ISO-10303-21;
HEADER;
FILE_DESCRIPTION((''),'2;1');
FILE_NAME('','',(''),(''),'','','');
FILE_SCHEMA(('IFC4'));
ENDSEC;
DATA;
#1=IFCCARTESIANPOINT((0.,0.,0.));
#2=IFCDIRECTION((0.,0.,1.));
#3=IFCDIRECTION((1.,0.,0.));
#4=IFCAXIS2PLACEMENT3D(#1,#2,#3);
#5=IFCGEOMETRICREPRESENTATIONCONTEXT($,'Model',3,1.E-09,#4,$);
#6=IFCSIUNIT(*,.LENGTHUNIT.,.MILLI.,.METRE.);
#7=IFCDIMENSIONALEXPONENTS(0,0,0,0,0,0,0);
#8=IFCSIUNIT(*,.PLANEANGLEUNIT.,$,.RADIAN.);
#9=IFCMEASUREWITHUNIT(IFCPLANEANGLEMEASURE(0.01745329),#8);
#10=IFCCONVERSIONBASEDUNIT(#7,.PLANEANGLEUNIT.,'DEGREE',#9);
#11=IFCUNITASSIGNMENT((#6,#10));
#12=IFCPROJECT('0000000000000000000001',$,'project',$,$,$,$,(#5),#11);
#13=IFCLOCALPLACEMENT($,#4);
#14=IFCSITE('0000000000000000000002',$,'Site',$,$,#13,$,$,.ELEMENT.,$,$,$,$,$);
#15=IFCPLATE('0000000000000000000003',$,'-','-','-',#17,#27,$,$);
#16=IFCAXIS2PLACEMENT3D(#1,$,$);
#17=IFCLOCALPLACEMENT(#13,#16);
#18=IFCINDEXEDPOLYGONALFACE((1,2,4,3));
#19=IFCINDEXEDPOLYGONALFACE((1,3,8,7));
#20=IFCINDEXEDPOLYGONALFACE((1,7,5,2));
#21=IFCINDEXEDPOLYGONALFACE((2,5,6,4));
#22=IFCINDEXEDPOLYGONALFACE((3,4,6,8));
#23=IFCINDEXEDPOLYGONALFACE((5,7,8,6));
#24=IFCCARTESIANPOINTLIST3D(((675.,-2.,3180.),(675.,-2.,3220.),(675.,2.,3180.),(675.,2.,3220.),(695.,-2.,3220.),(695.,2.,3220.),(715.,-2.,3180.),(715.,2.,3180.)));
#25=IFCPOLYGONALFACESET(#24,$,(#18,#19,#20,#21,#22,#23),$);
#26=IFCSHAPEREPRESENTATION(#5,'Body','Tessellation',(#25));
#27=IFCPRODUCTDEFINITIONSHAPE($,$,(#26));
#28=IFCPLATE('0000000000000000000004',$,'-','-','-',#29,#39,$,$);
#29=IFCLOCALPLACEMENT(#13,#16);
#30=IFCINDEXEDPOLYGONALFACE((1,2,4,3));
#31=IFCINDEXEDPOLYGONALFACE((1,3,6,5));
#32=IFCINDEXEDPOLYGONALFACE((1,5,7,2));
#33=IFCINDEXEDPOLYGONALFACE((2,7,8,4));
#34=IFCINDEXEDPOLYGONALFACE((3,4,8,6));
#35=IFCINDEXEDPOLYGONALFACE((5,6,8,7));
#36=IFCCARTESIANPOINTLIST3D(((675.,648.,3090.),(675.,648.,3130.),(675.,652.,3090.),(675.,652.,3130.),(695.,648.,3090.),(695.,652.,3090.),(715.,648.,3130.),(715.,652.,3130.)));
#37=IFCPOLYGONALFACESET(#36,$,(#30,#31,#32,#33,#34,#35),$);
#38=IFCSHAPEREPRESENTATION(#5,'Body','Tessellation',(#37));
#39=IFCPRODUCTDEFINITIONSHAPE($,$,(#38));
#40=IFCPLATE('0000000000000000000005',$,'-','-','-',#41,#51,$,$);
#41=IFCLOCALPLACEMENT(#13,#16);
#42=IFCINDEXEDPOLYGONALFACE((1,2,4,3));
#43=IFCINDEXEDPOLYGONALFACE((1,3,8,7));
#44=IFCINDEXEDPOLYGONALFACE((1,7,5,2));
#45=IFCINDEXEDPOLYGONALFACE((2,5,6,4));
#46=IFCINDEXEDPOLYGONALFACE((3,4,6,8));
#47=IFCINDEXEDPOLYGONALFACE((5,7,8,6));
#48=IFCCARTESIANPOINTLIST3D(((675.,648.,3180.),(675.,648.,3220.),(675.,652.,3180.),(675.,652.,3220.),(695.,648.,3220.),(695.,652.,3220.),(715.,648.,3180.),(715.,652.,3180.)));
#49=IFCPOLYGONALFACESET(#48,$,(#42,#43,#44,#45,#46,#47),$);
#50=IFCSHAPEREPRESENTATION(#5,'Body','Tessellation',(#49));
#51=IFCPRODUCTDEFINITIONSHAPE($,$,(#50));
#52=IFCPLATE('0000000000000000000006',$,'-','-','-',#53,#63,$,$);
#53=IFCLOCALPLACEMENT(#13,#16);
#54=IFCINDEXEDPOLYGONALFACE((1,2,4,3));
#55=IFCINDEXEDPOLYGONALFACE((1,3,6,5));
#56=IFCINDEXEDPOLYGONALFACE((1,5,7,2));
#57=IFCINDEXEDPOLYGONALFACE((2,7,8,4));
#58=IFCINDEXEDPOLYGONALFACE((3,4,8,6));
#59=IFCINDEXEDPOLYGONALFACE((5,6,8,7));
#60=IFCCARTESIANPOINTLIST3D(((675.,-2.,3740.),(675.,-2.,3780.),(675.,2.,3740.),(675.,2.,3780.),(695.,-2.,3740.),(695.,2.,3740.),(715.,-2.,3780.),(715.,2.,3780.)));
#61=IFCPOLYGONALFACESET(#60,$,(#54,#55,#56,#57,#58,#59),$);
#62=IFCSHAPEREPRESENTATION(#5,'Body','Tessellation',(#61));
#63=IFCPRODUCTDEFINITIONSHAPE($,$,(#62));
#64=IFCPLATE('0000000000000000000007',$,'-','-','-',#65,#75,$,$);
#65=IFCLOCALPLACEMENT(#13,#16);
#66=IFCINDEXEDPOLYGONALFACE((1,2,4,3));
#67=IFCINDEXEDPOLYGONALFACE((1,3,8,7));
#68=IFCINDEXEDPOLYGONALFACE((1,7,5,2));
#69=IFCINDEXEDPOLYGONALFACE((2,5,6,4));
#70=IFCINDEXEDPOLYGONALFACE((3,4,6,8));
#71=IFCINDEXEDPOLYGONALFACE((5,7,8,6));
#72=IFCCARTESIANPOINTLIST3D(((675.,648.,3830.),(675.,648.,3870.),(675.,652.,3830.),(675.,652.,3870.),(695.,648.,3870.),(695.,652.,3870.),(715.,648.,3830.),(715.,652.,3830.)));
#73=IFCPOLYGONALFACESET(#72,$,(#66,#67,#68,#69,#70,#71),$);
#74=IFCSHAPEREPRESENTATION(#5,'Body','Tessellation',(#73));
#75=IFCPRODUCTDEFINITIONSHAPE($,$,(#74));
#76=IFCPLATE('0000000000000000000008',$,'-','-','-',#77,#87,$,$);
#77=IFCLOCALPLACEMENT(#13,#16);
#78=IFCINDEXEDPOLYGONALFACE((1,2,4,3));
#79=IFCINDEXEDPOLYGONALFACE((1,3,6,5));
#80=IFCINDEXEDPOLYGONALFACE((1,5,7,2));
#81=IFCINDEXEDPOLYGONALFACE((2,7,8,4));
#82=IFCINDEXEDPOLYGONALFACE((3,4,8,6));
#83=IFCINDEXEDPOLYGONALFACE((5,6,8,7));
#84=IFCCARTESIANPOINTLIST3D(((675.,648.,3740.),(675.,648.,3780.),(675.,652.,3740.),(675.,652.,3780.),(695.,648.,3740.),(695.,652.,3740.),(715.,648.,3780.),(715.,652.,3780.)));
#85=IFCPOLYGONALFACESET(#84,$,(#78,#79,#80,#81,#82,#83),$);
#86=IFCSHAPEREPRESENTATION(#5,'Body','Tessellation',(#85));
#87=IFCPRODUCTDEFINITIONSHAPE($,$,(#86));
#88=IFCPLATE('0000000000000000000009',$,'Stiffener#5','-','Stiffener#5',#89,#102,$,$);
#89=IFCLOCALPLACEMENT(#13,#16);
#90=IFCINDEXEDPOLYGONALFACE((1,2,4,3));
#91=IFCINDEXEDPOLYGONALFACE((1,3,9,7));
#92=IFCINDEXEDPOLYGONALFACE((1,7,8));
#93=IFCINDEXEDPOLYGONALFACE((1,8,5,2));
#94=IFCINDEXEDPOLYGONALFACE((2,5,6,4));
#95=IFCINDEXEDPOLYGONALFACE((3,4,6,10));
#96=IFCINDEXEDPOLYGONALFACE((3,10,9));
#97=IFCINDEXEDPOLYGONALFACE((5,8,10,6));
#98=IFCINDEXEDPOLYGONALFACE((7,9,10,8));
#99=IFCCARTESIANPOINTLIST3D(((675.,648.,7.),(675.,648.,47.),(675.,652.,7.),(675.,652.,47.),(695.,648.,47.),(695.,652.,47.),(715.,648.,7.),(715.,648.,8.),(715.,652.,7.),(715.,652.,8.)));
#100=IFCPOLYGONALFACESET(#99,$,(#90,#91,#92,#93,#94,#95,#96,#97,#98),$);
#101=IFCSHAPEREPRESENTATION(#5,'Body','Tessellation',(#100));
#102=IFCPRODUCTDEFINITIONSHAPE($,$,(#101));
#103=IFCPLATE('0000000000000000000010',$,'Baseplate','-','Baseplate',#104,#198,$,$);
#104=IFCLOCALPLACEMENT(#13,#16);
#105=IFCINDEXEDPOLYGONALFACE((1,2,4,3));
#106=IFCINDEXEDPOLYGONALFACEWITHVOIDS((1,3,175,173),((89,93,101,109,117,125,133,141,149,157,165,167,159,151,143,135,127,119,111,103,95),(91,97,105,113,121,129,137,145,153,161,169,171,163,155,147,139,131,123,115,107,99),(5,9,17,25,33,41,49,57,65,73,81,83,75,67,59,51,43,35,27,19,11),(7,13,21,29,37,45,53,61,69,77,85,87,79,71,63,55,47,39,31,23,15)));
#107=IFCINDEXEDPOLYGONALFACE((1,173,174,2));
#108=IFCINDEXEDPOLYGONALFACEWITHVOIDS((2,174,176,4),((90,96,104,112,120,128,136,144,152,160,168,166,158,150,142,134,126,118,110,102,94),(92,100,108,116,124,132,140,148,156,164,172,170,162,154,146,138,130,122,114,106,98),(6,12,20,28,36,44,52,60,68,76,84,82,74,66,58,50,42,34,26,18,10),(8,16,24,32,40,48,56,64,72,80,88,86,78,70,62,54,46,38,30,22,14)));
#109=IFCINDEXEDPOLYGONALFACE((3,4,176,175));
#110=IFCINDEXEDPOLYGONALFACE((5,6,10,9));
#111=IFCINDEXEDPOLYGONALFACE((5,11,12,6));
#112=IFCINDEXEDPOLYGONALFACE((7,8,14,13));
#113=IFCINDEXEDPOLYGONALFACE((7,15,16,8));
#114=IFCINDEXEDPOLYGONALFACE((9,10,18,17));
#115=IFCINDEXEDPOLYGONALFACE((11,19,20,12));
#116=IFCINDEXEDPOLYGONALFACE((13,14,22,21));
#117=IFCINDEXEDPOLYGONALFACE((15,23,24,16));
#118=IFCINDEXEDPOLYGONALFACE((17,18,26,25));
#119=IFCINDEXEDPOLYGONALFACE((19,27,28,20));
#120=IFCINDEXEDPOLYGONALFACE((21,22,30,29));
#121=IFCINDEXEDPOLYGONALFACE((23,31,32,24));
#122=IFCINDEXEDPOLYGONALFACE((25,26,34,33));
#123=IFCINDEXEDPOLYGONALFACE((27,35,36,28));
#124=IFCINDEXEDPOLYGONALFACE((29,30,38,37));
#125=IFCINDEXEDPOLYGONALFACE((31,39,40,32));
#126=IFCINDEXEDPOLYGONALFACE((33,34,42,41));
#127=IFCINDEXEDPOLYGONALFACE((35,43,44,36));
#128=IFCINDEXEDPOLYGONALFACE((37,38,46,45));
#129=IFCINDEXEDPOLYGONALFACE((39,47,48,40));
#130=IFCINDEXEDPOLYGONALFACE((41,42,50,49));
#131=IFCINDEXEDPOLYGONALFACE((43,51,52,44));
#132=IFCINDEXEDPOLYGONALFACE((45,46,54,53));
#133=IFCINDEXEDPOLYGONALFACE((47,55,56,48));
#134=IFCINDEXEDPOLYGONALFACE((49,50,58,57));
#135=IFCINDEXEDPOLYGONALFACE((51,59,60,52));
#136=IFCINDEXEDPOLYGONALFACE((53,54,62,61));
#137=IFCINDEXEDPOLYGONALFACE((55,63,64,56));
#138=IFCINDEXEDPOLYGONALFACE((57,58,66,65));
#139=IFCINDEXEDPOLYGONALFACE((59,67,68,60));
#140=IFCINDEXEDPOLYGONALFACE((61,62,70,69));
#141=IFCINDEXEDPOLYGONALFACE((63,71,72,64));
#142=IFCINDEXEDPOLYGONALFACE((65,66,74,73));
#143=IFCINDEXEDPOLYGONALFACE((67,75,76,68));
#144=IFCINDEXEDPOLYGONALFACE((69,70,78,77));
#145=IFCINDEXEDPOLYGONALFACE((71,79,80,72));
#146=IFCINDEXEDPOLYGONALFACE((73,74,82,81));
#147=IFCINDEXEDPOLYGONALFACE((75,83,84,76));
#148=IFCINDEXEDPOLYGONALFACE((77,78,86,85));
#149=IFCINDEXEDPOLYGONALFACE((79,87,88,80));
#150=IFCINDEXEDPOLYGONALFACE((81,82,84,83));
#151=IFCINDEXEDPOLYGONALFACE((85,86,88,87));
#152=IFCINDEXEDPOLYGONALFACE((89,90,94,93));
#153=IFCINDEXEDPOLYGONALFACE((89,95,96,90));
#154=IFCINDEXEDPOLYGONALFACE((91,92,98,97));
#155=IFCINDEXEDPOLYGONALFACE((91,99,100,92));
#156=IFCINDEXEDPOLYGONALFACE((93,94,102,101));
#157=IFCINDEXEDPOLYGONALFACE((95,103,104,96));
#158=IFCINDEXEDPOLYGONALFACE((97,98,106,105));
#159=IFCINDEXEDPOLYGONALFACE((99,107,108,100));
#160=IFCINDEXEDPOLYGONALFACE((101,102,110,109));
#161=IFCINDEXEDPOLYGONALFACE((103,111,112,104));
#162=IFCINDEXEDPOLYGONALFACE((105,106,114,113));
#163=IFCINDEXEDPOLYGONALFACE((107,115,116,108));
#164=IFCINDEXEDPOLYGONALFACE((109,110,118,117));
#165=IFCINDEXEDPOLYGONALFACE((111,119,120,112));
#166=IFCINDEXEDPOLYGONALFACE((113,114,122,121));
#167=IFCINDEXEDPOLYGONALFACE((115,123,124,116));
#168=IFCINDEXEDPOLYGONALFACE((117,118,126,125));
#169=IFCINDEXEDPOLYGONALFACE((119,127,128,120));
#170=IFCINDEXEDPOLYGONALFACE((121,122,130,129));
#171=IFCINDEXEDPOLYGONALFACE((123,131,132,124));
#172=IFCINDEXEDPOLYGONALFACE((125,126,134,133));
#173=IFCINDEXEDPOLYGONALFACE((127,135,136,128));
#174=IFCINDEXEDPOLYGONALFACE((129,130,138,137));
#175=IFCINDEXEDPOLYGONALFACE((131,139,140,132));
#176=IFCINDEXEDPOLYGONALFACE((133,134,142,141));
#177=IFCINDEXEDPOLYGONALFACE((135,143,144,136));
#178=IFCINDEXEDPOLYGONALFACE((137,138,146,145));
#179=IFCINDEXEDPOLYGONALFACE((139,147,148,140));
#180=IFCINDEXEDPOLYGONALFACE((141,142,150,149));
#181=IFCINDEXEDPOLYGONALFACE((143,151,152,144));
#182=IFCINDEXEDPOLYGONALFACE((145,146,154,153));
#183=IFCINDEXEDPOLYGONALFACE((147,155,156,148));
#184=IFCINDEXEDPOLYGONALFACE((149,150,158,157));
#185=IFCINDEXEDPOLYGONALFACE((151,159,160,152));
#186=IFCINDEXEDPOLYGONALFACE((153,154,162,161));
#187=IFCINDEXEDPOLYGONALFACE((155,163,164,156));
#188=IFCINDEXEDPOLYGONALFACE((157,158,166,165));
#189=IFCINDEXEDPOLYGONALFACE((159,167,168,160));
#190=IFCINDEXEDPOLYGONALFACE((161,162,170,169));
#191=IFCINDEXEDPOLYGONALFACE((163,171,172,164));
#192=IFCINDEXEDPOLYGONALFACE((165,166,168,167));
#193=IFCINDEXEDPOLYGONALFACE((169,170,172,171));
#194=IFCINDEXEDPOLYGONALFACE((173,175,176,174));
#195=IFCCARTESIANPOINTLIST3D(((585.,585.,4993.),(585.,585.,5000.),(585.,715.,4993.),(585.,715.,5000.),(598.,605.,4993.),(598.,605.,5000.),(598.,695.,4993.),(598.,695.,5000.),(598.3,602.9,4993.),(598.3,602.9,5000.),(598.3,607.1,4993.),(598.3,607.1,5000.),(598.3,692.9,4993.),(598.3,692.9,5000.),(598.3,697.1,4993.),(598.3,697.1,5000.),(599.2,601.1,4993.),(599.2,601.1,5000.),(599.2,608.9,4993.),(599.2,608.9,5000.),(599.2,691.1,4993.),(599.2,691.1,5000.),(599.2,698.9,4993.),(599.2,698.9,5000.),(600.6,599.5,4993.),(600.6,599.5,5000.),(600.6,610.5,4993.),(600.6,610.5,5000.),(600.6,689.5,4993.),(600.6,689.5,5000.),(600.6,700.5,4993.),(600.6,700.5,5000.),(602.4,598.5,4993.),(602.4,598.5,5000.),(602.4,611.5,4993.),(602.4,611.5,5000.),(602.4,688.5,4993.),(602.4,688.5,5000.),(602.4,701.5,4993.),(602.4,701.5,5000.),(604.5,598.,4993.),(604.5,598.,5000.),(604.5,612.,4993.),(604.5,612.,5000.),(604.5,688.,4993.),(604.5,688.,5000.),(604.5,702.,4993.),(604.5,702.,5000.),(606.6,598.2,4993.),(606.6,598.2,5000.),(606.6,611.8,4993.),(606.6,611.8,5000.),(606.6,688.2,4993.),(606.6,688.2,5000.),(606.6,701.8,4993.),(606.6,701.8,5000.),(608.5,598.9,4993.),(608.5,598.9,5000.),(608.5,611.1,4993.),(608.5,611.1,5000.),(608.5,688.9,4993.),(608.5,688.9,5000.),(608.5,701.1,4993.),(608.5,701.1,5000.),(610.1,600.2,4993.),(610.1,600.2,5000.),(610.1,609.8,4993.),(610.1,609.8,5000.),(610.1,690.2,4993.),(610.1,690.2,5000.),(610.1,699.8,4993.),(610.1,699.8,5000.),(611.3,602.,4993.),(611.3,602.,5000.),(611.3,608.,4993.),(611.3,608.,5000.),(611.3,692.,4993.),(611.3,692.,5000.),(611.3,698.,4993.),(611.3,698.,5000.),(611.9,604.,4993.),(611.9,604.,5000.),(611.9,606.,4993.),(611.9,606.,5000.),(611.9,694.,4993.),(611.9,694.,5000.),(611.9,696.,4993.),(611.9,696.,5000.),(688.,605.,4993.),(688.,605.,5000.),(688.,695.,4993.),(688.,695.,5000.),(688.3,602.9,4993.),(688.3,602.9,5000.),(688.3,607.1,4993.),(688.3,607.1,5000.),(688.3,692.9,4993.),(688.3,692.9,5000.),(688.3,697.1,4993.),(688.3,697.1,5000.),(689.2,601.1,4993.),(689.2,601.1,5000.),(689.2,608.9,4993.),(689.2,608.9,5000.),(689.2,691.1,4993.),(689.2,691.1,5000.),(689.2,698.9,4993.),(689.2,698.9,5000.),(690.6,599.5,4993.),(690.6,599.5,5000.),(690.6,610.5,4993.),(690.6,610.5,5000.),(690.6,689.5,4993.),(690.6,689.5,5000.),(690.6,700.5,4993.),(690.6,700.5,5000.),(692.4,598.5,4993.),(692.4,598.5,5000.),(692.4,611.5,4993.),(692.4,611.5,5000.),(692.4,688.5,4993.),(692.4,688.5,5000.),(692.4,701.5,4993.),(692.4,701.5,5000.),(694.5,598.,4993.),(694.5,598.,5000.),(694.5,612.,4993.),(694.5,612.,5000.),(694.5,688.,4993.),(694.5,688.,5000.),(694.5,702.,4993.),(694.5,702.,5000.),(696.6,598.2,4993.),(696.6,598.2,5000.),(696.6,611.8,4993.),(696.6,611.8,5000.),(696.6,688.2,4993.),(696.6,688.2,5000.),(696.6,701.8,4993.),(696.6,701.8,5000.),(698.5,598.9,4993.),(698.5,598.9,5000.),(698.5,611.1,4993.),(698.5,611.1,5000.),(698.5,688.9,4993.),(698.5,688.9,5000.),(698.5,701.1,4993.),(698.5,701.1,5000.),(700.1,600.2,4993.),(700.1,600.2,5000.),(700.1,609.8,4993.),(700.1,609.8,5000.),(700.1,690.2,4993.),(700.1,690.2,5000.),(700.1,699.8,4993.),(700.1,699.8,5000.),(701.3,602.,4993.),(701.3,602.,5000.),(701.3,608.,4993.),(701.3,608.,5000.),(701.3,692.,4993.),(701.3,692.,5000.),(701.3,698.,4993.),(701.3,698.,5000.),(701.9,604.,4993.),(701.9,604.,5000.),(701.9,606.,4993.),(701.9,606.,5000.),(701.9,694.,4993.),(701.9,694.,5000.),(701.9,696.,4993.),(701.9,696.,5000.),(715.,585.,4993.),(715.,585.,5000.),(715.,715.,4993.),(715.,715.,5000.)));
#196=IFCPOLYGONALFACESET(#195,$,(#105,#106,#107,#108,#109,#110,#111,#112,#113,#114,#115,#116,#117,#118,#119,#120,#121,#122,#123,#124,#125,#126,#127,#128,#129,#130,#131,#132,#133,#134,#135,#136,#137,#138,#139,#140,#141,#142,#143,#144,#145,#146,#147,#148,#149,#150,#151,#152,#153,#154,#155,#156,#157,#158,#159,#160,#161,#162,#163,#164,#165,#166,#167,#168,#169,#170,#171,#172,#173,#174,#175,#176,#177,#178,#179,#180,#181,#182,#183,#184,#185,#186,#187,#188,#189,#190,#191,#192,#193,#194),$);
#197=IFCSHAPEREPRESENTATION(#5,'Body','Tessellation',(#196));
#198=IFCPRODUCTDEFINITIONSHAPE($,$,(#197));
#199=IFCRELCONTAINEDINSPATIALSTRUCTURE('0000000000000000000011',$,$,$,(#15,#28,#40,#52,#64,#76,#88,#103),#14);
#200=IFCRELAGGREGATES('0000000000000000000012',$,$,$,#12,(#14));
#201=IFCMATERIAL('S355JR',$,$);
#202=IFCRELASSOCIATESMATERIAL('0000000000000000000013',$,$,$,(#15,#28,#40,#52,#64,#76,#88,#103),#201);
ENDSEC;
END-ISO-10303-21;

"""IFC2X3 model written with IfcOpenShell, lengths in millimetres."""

from ifc_helpers import new_model, entity, si_unit, converted_unit, frame, frame_2d, origin, origin_with_axes, place, context, project, spatial, polyline, circle, outline, extrude, material, element, save


model = new_model("IFC2X3")

# Units and contexts
model_context = context("Model", 3, precision=1e-09, world=origin_with_axes())
ifc_project = project(units=[si_unit("LENGTHUNIT", "METRE", prefix="MILLI"), converted_unit("PLANEANGLEUNIT", "DEGREE", entity("IfcPlaneAngleMeasure", 0.01745329), si_unit("PLANEANGLEUNIT", "RADIAN"), dimensions=[0, 0, 0, 0, 0, 0, 0])], contexts=[model_context])

# Site
site_placement = place(None, origin_with_axes())
site = spatial("IfcSite", under=ifc_project, at=site_placement, Name="Site", CompositionType="ELEMENT")

# Shared definitions
ifc_material_1 = material(Name="S355JR")

# Plates
for number, where, z_axis, x_axis, name in (
    (1, (675.0, -2.0, 3180.0), (0.0, 1.0, 0.0), (0.0, 0.0, 1.0), "-"),
    (2, (675.0, 652.0, 3130.0), (0.0, -1.0, 0.0), (0.0, 0.0, -1.0), "-"),
):
    element("IfcPlate", number, at=place(None, frame(where, z_axis=z_axis, x_axis=x_axis)), inside=site, material=ifc_material_1, Name=name, Description="-", ObjectType="-", context=model_context, shape_type="SweptSolid", body=[
        extrude(outline(polyline([(0.0, 0.0), (40.0, 0.0), (40.0, 20.0), (0.0, 40.0), (0.0, 0.0)])), origin_with_axes(), (0.0, 0.0, 1.0), 4.0),
    ])
for number, where, z_axis, x_axis, name in (
    (3, (675.0, 652.0, 3180.0), (0.0, 1.0, 0.0), (0.0, 0.0, 1.0), "-"),
    (4, (675.0, -2.0, 3780.0), (0.0, -1.0, 0.0), (0.0, 0.0, -1.0), "-"),
    (5, (675.0, 652.0, 3830.0), (0.0, 1.0, 0.0), (0.0, 0.0, 1.0), "-"),
):
    element("IfcPlate", number, at=place(None, frame(where, z_axis=z_axis, x_axis=x_axis)), inside=site, material=ifc_material_1, Name=name, Description="-", ObjectType="-", context=model_context, shape_type="SweptSolid", body=[
        extrude(outline(polyline([(0.0, 0.0), (40.0, 0.0), (40.0, 20.0), (0.0, 40.0), (0.0, 0.0)])), origin_with_axes(), (0.0, 0.0, -1.0), 4.0),
    ])
plate_1_placement = place(None, frame((675.0, 652.0, 3780.0), z_axis=(0.0, -1.0, 0.0), x_axis=(0.0, 0.0, -1.0)))
element("IfcPlate", 6, at=plate_1_placement, inside=site, material=ifc_material_1, Name="-", Description="-", ObjectType="-", context=model_context, shape_type="SweptSolid", body=[
    extrude(outline(polyline([(0.0, 0.0), (40.0, 0.0), (40.0, 20.0), (0.0, 40.0), (0.0, 0.0)])), origin_with_axes(), (0.0, 0.0, 1.0), 4.0),
])

# Plate, opening
plate_2_placement = place(None, frame((675.0, 648.0, 7.0), z_axis=(0.0, 1.0, 0.0), x_axis=(0.0, 0.0, 1.0)))
plate_2 = element("IfcPlate", 7, at=plate_2_placement, inside=site, material=ifc_material_1, Name="Stiffener#5", Description="-", ObjectType="Stiffener#5", context=model_context, shape_type="SweptSolid", body=[
    extrude(outline(polyline([(0.0, 0.0), (40.0, 0.0), (40.0, 40.0), (0.0, 40.0), (0.0, 0.0)])), origin_with_axes(), (0.0, 0.0, 1.0), 4.0),
])
opening_1_placement = place(plate_2_placement, frame((0.0, 0.0, 0.0), z_axis=(0.0, 0.0, 1.0), x_axis=(1.0, 0.0, 0.0)))
element("IfcOpeningElement", 8, at=opening_1_placement, cuts=plate_2, ObjectType="Opening", context=model_context, shape_type="SweptSolid", body=[
    extrude(outline(polyline([(40.0, 40.0), (1.0, 40.0), (40.0, 20.0), (40.0, 40.0)])), origin(), (0.0, 0.0, 1.0), 4.0),
])

# Plate, openings
plate_3_placement = place(None, frame((715.0, 715.0, 4993.0), z_axis=(0.0, 0.0, 1.0), x_axis=(-1.0, 0.0, 0.0)))
plate_3 = element("IfcPlate", 9, at=plate_3_placement, inside=site, material=ifc_material_1, Name="Baseplate", Description="-", ObjectType="Baseplate", context=model_context, shape_type="SweptSolid", body=[
    extrude(outline(polyline([(0.0, 0.0), (130.0, 0.0), (130.0, 130.0), (0.0, 130.0), (0.0, 0.0)])), origin_with_axes(), (0.0, 0.0, 1.0), 7.0),
])
opening_2_placement = place(plate_3_placement, frame((20.0, 65.0, 7.5), z_axis=(0.0, 0.0, -1.0), x_axis=(1.0, 0.0, 0.0)))
element("IfcOpeningElement", 10, at=opening_2_placement, cuts=plate_3, ObjectType="Opening", context=model_context, shape_type="SweptSolid", body=[
    extrude(circle(Radius=7.0, at=frame_2d((0.0, 45.0), x_axis=(1.0, 0.0))), origin(), (0.0, 0.0, 1.0), 8.0),
])
opening_3_placement = place(plate_3_placement, frame((20.0, 65.0, 7.5), z_axis=(0.0, 0.0, -1.0), x_axis=(1.0, 0.0, 0.0)))
element("IfcOpeningElement", 11, at=opening_3_placement, cuts=plate_3, ObjectType="Opening", context=model_context, shape_type="SweptSolid", body=[
    extrude(circle(Radius=7.0, at=frame_2d((0.0, -45.0), x_axis=(1.0, 0.0))), origin(), (0.0, 0.0, 1.0), 8.0),
])
opening_4_placement = place(plate_3_placement, frame((110.0, 65.0, 7.5), z_axis=(0.0, 0.0, -1.0), x_axis=(1.0, 0.0, 0.0)))
element("IfcOpeningElement", 12, at=opening_4_placement, cuts=plate_3, ObjectType="Opening", context=model_context, shape_type="SweptSolid", body=[
    extrude(circle(Radius=7.0, at=frame_2d((0.0, 45.0), x_axis=(1.0, 0.0))), origin(), (0.0, 0.0, 1.0), 8.0),
])
opening_5_placement = place(plate_3_placement, frame((110.0, 65.0, 7.5), z_axis=(0.0, 0.0, -1.0), x_axis=(1.0, 0.0, 0.0)))
element("IfcOpeningElement", 13, at=opening_5_placement, cuts=plate_3, ObjectType="Opening", context=model_context, shape_type="SweptSolid", body=[
    extrude(circle(Radius=7.0, at=frame_2d((0.0, -45.0), x_axis=(1.0, 0.0))), origin(), (0.0, 0.0, 1.0), 8.0),
])

save(model, "model.ifc")
